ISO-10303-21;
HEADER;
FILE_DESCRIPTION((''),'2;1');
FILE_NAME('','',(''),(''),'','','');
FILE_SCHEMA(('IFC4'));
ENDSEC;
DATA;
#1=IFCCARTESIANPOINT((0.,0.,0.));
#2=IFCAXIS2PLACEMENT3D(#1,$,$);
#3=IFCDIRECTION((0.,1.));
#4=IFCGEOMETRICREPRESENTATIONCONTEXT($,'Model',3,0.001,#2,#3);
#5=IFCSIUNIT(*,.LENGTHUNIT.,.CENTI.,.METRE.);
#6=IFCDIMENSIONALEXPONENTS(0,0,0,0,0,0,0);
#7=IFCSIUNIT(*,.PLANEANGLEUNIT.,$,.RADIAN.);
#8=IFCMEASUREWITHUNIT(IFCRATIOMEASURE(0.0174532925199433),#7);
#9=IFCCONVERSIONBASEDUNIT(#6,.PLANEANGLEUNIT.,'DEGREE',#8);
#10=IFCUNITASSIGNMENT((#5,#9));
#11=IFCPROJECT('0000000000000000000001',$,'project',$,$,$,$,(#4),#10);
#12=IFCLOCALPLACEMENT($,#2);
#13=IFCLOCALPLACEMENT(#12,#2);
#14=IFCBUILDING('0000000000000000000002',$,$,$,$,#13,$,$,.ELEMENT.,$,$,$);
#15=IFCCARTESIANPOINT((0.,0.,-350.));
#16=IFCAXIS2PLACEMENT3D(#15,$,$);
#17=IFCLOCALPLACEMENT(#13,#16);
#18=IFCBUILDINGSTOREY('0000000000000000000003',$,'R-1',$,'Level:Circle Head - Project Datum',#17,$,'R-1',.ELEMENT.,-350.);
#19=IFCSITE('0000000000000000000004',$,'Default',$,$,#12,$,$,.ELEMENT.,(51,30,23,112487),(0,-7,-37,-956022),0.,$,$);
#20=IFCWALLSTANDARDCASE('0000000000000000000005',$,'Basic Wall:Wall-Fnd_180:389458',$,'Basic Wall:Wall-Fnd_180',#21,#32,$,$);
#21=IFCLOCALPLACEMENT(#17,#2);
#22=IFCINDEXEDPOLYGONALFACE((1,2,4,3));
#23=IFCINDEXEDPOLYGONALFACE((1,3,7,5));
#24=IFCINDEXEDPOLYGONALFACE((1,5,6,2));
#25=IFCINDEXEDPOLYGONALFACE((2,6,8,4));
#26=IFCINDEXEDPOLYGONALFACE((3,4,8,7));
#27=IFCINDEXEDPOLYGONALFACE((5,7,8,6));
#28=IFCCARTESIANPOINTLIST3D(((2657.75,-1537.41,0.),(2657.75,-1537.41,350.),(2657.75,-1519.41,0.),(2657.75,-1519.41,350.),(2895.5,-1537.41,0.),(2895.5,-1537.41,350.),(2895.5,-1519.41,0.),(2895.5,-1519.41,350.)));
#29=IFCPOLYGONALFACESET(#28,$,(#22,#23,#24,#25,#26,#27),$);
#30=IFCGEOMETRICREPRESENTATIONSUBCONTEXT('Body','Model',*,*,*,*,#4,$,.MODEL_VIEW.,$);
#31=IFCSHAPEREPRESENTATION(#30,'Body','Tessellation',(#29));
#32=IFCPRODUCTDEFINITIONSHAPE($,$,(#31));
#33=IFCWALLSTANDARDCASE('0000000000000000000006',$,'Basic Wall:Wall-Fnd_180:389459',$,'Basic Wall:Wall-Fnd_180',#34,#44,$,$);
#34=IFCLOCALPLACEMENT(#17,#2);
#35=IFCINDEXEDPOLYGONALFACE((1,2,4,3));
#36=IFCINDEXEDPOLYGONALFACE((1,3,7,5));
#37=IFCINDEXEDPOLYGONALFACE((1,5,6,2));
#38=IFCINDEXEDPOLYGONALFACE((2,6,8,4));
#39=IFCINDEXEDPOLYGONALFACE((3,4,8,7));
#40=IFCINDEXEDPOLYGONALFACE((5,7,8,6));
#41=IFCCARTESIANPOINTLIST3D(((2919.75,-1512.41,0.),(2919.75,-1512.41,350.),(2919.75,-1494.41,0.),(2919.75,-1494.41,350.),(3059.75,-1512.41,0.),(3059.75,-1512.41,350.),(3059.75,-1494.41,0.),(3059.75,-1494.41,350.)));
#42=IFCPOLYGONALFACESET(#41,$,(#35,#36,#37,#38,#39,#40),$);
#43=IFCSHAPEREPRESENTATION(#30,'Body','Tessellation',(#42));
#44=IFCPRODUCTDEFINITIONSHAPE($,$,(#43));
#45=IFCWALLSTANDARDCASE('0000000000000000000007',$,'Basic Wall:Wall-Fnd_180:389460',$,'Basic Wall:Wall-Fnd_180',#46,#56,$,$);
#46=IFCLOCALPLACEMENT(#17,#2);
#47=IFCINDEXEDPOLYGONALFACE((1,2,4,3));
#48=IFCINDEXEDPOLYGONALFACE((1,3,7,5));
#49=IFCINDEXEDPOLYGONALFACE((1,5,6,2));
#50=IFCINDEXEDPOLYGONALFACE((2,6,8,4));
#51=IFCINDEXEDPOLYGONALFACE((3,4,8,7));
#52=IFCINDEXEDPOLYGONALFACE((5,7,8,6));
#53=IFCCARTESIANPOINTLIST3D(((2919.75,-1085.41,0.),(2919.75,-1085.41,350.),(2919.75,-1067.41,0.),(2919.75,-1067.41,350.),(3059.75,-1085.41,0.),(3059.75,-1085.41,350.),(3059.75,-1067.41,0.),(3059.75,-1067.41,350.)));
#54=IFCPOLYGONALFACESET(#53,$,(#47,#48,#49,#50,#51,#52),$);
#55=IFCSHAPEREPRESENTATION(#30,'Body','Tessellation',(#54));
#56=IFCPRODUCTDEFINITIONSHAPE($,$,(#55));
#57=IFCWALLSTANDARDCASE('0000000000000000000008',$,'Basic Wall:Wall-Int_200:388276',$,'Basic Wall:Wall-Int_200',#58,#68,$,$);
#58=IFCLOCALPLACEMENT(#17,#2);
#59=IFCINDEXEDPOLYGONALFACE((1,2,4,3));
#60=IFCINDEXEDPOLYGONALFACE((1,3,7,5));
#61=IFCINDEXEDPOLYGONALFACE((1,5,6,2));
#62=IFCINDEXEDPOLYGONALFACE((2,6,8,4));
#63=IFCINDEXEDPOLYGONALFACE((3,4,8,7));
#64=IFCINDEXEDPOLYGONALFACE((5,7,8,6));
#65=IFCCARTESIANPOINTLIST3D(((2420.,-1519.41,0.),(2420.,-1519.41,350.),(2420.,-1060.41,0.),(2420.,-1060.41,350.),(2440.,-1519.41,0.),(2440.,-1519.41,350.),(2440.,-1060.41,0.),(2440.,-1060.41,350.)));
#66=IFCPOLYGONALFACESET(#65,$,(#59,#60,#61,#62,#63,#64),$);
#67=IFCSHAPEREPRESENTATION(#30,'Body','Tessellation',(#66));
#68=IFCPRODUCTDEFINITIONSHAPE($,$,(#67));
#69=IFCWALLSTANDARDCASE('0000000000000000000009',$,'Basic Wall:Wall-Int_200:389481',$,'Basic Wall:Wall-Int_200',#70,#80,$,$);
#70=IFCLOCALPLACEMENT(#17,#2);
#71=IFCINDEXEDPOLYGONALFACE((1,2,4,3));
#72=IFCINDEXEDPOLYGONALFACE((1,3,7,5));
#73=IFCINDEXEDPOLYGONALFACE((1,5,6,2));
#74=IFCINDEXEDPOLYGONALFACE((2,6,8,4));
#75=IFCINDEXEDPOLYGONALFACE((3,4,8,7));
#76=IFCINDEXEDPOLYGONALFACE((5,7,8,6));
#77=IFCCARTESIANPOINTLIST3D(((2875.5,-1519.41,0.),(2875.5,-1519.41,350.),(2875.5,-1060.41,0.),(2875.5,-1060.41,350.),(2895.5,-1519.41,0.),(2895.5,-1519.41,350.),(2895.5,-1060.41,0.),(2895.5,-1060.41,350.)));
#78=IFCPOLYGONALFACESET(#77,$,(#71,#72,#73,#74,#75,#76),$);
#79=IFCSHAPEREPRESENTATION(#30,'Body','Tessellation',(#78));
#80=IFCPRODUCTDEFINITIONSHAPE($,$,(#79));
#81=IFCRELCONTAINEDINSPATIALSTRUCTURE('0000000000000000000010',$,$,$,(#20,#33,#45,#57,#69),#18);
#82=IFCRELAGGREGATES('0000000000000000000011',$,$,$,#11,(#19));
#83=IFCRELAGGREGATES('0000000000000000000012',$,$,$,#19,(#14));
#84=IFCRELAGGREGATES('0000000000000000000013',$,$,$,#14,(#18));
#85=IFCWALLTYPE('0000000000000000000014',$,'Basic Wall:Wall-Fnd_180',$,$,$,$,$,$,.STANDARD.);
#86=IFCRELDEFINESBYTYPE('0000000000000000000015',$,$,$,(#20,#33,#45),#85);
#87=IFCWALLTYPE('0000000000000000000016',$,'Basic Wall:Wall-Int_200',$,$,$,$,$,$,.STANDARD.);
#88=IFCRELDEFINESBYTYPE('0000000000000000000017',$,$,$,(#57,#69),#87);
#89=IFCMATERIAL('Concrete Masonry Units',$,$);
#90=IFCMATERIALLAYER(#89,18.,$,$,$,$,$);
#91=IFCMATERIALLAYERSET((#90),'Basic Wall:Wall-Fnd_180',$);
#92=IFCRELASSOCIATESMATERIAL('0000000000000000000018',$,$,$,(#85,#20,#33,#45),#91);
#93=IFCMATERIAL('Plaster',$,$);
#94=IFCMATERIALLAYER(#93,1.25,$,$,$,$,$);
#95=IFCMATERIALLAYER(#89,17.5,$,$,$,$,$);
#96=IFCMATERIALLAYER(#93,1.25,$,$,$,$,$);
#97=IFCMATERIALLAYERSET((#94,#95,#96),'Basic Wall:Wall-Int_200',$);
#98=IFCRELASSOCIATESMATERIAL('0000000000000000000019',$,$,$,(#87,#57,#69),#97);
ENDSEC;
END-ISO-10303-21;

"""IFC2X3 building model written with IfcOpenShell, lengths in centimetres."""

from ifc_helpers import new_model, entity, si_unit, converted_unit, direction, frame, frame_2d, origin, place, context, subcontext, project, spatial, rectangle, extrude, material, layer, layer_set, layer_usage, type_object, element, save


model = new_model("IFC2X3")

# Units and contexts
model_context = context("Model", 3, precision=0.001, world=origin(), true_north=direction((0.0, 1.0)))
body_context = subcontext(model_context, "Body", "Model", "MODEL_VIEW")
ifc_project = project(units=[si_unit("LENGTHUNIT", "METRE", prefix="CENTI"), converted_unit("PLANEANGLEUNIT", "DEGREE", entity("IfcRatioMeasure", 0.0174532925199433), si_unit("PLANEANGLEUNIT", "RADIAN"), dimensions=[0, 0, 0, 0, 0, 0, 0])], contexts=[model_context])

# Site, building, storey
site_placement = place(None, origin())
site = spatial("IfcSite", under=ifc_project, at=site_placement, Name="Default", CompositionType="ELEMENT", RefLatitude=(51, 30, 23, 112487), RefLongitude=(0, -7, -37, -956022), RefElevation=0.0)
building_placement = place(site_placement, origin())
building = spatial("IfcBuilding", under=site, at=building_placement, CompositionType="ELEMENT")
storey_placement = place(building_placement, frame((0.0, 0.0, -350.0)))
storey = spatial("IfcBuildingStorey", under=building, at=storey_placement, Name="R-1", ObjectType="Level:Circle Head - Project Datum", LongName="R-1", CompositionType="ELEMENT", Elevation=-350.0)

# Walls
ifc_material_1 = material(Name="Concrete Masonry Units")
ifc_layer_1 = layer(ifc_material_1, 18.0)
ifc_layer_set_1 = layer_set([ifc_layer_1], Name="Basic Wall:Wall-Fnd_180")
wall_type_1 = type_object("IfcWallType", Name="Basic Wall:Wall-Fnd_180", PredefinedType="STANDARD", material=ifc_layer_set_1)
ifc_layer_usage_1 = layer_usage(ifc_layer_set_1, "AXIS2", "NEGATIVE", 9.0)
wall_1_placement = place(storey_placement, frame((2895.5, -1528.41, 0.0), z_axis=(0.0, 0.0, 1.0), x_axis=(-1.0, 0.0, 0.0)))
element("IfcWallStandardCase", 1, at=wall_1_placement, inside=storey, type_object=wall_type_1, material=ifc_layer_usage_1, Name="Basic Wall:Wall-Fnd_180:389458", ObjectType="Basic Wall:Wall-Fnd_180", context=body_context, shape_type="SweptSolid", body=[
    extrude(rectangle(XDim=237.75, YDim=18.0, at=frame_2d((118.88, 0.0), x_axis=(-1.0, 0.0))), origin(), (0.0, 0.0, 1.0), 350.0),
])
ifc_layer_usage_2 = layer_usage(ifc_layer_set_1, "AXIS2", "POSITIVE", -9.0)
wall_2_placement = place(storey_placement, frame((3059.75, -1503.41, 0.0), z_axis=(0.0, 0.0, 1.0), x_axis=(-1.0, 0.0, 0.0)))
element("IfcWallStandardCase", 2, at=wall_2_placement, inside=storey, type_object=wall_type_1, material=ifc_layer_usage_2, Name="Basic Wall:Wall-Fnd_180:389459", ObjectType="Basic Wall:Wall-Fnd_180", context=body_context, shape_type="SweptSolid", body=[
    extrude(rectangle(XDim=140.0, YDim=18.0, at=frame_2d((70.0, 0.0), x_axis=(-1.0, 0.0))), origin(), (0.0, 0.0, 1.0), 350.0),
])
ifc_layer_usage_3 = layer_usage(ifc_layer_set_1, "AXIS2", "NEGATIVE", 9.0)
wall_3_placement = place(storey_placement, frame((3059.75, -1076.41, 0.0), z_axis=(0.0, 0.0, 1.0), x_axis=(-1.0, 0.0, 0.0)))
element("IfcWallStandardCase", 3, at=wall_3_placement, inside=storey, type_object=wall_type_1, material=ifc_layer_usage_3, Name="Basic Wall:Wall-Fnd_180:389460", ObjectType="Basic Wall:Wall-Fnd_180", context=body_context, shape_type="SweptSolid", body=[
    extrude(rectangle(XDim=140.0, YDim=18.0, at=frame_2d((70.0, 0.0), x_axis=(-1.0, 0.0))), origin(), (0.0, 0.0, 1.0), 350.0),
])
ifc_material_2 = material(Name="Plaster")
ifc_layer_2 = layer(ifc_material_2, 1.25)
ifc_layer_3 = layer(ifc_material_1, 17.5)
ifc_layer_4 = layer(ifc_material_2, 1.25)
ifc_layer_set_2 = layer_set([ifc_layer_2, ifc_layer_3, ifc_layer_4], Name="Basic Wall:Wall-Int_200")
ifc_layer_usage_4 = layer_usage(ifc_layer_set_2, "AXIS2", "NEGATIVE", 10.0)
wall_type_2 = type_object("IfcWallType", Name="Basic Wall:Wall-Int_200", PredefinedType="STANDARD", material=ifc_layer_set_2)
wall_4_placement = place(storey_placement, frame((2430.0, -1060.41, 0.0), z_axis=(0.0, 0.0, 1.0), x_axis=(0.0, -1.0, 0.0)))
element("IfcWallStandardCase", 4, at=wall_4_placement, inside=storey, type_object=wall_type_2, material=ifc_layer_usage_4, Name="Basic Wall:Wall-Int_200:388276", ObjectType="Basic Wall:Wall-Int_200", context=body_context, shape_type="SweptSolid", body=[
    extrude(rectangle(XDim=459.0, YDim=20.0, at=frame_2d((229.5, 0.0), x_axis=(-1.0, 0.0))), origin(), (0.0, 0.0, 1.0), 350.0),
])
ifc_layer_usage_5 = layer_usage(ifc_layer_set_2, "AXIS2", "POSITIVE", -10.0)
wall_5_placement = place(storey_placement, frame((2885.5, -1060.41, 0.0), z_axis=(0.0, 0.0, 1.0), x_axis=(0.0, -1.0, 0.0)))
element("IfcWallStandardCase", 5, at=wall_5_placement, inside=storey, type_object=wall_type_2, material=ifc_layer_usage_5, Name="Basic Wall:Wall-Int_200:389481", ObjectType="Basic Wall:Wall-Int_200", context=body_context, shape_type="SweptSolid", body=[
    extrude(rectangle(XDim=459.0, YDim=20.0, at=frame_2d((229.5, 0.0), x_axis=(-1.0, 0.0))), origin(), (0.0, 0.0, 1.0), 350.0),
])

save(model, "model.ifc")
